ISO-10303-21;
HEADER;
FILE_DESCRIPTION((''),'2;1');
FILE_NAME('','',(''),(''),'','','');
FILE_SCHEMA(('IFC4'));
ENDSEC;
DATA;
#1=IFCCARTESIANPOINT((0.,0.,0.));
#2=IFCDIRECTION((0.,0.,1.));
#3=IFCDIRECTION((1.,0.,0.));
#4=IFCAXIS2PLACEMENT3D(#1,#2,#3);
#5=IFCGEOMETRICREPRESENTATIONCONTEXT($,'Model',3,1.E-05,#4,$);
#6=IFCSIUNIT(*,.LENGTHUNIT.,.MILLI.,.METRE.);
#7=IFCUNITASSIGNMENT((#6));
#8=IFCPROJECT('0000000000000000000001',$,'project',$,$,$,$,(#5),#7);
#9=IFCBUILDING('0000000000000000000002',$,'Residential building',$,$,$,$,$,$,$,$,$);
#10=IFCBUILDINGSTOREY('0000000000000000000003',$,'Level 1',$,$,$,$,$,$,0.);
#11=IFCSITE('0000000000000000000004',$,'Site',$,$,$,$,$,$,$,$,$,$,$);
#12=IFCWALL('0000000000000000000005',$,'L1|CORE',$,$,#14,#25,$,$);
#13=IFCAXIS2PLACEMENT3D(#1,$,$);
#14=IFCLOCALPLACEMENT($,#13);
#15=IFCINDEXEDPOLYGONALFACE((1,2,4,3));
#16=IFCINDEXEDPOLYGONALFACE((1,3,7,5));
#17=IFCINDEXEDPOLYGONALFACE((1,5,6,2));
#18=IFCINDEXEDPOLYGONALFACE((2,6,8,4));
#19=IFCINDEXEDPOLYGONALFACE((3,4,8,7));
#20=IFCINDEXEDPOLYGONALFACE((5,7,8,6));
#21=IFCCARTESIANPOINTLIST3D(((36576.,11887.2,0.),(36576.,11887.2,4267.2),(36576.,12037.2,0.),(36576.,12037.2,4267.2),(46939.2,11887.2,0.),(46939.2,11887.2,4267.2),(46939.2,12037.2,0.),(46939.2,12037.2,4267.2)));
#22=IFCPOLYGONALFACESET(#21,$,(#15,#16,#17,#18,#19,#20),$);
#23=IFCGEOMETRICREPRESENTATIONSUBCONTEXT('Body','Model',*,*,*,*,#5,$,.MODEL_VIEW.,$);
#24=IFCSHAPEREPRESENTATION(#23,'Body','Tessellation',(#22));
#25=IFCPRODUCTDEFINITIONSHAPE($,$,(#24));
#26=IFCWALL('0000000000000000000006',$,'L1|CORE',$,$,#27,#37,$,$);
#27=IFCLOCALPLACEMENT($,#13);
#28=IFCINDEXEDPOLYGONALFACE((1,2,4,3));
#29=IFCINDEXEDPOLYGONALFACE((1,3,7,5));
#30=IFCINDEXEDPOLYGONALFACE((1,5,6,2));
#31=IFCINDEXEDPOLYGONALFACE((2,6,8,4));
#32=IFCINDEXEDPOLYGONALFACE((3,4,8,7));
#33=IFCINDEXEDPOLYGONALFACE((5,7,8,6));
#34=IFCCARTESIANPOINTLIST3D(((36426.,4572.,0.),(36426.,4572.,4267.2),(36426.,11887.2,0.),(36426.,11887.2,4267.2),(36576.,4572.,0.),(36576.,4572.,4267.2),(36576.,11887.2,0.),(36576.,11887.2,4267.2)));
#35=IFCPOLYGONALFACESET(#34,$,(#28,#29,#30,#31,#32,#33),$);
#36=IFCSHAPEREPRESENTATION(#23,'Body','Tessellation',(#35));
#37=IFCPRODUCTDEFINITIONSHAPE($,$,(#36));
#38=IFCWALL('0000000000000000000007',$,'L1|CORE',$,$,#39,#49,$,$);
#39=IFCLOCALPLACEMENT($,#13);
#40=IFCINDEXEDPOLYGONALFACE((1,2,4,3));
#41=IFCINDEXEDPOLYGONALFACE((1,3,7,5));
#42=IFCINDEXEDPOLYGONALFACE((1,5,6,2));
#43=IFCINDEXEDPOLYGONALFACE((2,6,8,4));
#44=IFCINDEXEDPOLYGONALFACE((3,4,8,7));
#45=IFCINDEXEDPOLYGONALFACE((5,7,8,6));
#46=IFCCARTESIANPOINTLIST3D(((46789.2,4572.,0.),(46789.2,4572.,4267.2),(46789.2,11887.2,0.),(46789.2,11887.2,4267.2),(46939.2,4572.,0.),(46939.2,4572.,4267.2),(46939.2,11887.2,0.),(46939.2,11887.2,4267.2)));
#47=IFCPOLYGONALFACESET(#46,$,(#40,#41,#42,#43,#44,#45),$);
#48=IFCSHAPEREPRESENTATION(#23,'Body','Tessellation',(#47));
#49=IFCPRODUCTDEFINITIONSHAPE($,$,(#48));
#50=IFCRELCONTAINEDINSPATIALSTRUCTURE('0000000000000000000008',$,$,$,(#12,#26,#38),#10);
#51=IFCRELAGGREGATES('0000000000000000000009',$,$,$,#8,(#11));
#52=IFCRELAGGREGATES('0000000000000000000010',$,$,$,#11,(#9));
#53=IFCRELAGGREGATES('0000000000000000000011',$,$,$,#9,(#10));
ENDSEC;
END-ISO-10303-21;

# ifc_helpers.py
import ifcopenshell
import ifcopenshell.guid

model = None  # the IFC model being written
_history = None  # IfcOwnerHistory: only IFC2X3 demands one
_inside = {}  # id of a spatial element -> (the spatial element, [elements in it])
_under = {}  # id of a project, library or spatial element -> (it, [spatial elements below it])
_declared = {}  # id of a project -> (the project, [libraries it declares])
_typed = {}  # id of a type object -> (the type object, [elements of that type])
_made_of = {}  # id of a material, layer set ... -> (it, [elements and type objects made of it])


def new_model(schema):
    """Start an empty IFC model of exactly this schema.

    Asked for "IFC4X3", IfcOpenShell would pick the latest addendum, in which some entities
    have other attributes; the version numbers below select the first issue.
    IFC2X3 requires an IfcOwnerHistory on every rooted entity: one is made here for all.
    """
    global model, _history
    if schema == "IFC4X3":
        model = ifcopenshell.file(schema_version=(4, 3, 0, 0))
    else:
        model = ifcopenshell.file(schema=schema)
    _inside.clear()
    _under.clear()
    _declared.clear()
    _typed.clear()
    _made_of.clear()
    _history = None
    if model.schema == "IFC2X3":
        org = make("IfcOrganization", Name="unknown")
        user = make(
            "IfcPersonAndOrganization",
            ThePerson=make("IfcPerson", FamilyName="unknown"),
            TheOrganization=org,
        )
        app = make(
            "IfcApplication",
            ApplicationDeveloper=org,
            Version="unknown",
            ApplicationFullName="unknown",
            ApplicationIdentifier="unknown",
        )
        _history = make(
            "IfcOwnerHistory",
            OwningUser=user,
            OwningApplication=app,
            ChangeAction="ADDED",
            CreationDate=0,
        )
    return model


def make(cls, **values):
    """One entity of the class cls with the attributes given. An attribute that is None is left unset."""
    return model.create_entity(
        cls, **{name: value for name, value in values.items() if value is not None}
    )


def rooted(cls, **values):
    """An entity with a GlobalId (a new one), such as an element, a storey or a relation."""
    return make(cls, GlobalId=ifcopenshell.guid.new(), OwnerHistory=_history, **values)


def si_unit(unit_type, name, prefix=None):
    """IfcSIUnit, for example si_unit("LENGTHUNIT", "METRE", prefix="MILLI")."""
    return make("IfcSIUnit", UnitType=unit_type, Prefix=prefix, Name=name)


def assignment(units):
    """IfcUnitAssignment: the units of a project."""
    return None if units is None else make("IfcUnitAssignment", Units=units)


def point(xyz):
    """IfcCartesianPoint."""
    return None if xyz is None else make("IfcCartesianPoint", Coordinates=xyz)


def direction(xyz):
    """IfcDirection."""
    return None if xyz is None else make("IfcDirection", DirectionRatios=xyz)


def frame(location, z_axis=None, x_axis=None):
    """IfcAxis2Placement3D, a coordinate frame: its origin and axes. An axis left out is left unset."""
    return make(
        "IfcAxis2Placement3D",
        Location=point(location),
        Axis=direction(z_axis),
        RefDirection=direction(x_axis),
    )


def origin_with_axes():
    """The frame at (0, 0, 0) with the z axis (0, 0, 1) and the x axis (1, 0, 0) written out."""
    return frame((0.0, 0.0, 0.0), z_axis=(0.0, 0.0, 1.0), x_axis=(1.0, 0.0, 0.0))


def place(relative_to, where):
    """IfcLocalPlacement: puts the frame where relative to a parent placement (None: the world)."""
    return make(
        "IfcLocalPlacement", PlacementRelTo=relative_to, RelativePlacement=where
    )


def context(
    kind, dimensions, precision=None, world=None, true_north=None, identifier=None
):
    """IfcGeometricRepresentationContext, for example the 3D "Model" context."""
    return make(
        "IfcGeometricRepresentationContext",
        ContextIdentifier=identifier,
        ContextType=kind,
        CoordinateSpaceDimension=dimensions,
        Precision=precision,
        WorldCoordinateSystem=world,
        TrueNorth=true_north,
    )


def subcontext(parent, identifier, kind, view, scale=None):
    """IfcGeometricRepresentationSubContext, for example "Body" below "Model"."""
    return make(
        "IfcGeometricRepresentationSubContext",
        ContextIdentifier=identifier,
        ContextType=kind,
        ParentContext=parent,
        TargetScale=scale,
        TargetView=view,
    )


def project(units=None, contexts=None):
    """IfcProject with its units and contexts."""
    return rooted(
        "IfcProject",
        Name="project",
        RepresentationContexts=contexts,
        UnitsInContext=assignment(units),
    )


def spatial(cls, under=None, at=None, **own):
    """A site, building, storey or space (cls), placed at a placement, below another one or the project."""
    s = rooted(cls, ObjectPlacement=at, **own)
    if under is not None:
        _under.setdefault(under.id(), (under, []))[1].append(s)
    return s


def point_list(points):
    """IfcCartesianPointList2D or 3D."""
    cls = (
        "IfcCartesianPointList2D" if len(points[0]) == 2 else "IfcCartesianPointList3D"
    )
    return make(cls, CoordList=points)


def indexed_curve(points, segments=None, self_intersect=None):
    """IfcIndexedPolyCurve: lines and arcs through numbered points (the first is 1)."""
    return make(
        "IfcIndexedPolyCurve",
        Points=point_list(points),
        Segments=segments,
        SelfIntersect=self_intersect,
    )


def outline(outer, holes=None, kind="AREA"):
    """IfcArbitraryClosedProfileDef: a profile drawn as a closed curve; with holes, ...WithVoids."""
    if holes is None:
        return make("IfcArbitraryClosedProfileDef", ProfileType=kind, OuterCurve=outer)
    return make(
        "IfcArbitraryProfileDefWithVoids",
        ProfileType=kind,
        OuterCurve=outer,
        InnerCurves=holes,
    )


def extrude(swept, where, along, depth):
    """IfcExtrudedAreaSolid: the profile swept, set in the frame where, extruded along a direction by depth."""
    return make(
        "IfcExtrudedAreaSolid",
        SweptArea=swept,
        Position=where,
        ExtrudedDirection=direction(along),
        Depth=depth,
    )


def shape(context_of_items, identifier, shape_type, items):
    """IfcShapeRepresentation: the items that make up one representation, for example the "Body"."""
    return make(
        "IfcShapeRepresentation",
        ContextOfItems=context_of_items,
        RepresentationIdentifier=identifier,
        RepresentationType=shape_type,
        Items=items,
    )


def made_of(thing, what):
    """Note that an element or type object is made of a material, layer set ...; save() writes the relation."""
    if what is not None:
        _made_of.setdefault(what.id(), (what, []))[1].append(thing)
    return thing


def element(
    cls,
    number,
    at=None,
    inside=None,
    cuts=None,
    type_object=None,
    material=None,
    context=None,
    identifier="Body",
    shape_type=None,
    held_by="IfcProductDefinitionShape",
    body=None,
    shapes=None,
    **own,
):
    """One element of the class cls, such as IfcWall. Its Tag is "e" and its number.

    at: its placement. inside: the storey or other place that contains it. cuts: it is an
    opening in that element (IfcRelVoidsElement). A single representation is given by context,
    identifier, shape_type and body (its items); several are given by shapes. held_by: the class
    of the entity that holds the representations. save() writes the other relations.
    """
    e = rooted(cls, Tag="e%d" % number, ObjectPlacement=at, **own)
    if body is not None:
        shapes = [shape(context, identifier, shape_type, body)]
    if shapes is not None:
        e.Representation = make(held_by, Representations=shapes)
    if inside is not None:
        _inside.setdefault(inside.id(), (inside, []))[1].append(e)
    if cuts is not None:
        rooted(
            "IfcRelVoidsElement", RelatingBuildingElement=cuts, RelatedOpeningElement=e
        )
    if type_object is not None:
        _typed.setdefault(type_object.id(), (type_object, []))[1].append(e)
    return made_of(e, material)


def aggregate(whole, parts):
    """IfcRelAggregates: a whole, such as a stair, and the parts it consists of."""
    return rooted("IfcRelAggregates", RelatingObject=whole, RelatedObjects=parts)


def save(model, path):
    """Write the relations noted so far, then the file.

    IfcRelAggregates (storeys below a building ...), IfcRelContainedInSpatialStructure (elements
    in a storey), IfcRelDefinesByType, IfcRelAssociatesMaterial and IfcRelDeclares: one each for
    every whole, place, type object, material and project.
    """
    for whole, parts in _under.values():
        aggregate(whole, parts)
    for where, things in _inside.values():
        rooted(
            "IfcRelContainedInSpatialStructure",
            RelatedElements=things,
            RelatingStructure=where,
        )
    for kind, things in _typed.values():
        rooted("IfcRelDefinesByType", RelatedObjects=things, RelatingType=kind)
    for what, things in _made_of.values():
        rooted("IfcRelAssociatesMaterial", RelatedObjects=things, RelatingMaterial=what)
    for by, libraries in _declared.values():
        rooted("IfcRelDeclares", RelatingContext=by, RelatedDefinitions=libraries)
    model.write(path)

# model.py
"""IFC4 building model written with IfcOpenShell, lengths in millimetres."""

from ifc_helpers import new_model, si_unit, frame, origin_with_axes, place, context, subcontext, project, spatial, indexed_curve, outline, extrude, element, save


model = new_model("IFC4")

# Units and contexts
model_context = context("Model", 3, precision=1e-05, world=origin_with_axes())
body_context = subcontext(model_context, "Body", "Model", "MODEL_VIEW")
ifc_project = project(units=[si_unit("LENGTHUNIT", "METRE", prefix="MILLI")], contexts=[model_context])

# Site, building, storey
site = spatial("IfcSite", under=ifc_project, Name="Site")
building = spatial("IfcBuilding", under=site, Name="Residential building")
storey = spatial("IfcBuildingStorey", under=building, Name="Level 1", Elevation=0.0)

# Walls
for number, where, z_axis, x_axis, name in (
    (1, (36576.0, 11887.2, 0.0), (0.0, 0.0, 1.0), (1.0, 0.0, 0.0), "L1|CORE"),
):
    element("IfcWall", number, at=place(None, frame(where, z_axis=z_axis, x_axis=x_axis)), inside=storey, Name=name, context=body_context, shape_type="SweptSolid", body=[
        extrude(outline(indexed_curve([(0.0, 0.0), (0.0, 150.0), (10363.2, 150.0), (10363.2, 0.0), (0.0, 0.0)], self_intersect=False)), origin_with_axes(), (0.0, 0.0, 1.0), 4267.2),
    ])
for number, where, z_axis, x_axis, name in (
    (2, (36576.0, 4572.0, 0.0), (0.0, 0.0, 1.0), (0.0, 1.0, 0.0), "L1|CORE"),
    (3, (46939.2, 4572.0, 0.0), (0.0, 0.0, 1.0), (0.0, 1.0, 0.0), "L1|CORE"),
):
    element("IfcWall", number, at=place(None, frame(where, z_axis=z_axis, x_axis=x_axis)), inside=storey, Name=name, context=body_context, shape_type="SweptSolid", body=[
        extrude(outline(indexed_curve([(0.0, 0.0), (0.0, 150.0), (7315.2, 150.0), (7315.2, 0.0), (0.0, 0.0)], self_intersect=False)), origin_with_axes(), (0.0, 0.0, 1.0), 4267.2),
    ])

save(model, "model.ifc")
